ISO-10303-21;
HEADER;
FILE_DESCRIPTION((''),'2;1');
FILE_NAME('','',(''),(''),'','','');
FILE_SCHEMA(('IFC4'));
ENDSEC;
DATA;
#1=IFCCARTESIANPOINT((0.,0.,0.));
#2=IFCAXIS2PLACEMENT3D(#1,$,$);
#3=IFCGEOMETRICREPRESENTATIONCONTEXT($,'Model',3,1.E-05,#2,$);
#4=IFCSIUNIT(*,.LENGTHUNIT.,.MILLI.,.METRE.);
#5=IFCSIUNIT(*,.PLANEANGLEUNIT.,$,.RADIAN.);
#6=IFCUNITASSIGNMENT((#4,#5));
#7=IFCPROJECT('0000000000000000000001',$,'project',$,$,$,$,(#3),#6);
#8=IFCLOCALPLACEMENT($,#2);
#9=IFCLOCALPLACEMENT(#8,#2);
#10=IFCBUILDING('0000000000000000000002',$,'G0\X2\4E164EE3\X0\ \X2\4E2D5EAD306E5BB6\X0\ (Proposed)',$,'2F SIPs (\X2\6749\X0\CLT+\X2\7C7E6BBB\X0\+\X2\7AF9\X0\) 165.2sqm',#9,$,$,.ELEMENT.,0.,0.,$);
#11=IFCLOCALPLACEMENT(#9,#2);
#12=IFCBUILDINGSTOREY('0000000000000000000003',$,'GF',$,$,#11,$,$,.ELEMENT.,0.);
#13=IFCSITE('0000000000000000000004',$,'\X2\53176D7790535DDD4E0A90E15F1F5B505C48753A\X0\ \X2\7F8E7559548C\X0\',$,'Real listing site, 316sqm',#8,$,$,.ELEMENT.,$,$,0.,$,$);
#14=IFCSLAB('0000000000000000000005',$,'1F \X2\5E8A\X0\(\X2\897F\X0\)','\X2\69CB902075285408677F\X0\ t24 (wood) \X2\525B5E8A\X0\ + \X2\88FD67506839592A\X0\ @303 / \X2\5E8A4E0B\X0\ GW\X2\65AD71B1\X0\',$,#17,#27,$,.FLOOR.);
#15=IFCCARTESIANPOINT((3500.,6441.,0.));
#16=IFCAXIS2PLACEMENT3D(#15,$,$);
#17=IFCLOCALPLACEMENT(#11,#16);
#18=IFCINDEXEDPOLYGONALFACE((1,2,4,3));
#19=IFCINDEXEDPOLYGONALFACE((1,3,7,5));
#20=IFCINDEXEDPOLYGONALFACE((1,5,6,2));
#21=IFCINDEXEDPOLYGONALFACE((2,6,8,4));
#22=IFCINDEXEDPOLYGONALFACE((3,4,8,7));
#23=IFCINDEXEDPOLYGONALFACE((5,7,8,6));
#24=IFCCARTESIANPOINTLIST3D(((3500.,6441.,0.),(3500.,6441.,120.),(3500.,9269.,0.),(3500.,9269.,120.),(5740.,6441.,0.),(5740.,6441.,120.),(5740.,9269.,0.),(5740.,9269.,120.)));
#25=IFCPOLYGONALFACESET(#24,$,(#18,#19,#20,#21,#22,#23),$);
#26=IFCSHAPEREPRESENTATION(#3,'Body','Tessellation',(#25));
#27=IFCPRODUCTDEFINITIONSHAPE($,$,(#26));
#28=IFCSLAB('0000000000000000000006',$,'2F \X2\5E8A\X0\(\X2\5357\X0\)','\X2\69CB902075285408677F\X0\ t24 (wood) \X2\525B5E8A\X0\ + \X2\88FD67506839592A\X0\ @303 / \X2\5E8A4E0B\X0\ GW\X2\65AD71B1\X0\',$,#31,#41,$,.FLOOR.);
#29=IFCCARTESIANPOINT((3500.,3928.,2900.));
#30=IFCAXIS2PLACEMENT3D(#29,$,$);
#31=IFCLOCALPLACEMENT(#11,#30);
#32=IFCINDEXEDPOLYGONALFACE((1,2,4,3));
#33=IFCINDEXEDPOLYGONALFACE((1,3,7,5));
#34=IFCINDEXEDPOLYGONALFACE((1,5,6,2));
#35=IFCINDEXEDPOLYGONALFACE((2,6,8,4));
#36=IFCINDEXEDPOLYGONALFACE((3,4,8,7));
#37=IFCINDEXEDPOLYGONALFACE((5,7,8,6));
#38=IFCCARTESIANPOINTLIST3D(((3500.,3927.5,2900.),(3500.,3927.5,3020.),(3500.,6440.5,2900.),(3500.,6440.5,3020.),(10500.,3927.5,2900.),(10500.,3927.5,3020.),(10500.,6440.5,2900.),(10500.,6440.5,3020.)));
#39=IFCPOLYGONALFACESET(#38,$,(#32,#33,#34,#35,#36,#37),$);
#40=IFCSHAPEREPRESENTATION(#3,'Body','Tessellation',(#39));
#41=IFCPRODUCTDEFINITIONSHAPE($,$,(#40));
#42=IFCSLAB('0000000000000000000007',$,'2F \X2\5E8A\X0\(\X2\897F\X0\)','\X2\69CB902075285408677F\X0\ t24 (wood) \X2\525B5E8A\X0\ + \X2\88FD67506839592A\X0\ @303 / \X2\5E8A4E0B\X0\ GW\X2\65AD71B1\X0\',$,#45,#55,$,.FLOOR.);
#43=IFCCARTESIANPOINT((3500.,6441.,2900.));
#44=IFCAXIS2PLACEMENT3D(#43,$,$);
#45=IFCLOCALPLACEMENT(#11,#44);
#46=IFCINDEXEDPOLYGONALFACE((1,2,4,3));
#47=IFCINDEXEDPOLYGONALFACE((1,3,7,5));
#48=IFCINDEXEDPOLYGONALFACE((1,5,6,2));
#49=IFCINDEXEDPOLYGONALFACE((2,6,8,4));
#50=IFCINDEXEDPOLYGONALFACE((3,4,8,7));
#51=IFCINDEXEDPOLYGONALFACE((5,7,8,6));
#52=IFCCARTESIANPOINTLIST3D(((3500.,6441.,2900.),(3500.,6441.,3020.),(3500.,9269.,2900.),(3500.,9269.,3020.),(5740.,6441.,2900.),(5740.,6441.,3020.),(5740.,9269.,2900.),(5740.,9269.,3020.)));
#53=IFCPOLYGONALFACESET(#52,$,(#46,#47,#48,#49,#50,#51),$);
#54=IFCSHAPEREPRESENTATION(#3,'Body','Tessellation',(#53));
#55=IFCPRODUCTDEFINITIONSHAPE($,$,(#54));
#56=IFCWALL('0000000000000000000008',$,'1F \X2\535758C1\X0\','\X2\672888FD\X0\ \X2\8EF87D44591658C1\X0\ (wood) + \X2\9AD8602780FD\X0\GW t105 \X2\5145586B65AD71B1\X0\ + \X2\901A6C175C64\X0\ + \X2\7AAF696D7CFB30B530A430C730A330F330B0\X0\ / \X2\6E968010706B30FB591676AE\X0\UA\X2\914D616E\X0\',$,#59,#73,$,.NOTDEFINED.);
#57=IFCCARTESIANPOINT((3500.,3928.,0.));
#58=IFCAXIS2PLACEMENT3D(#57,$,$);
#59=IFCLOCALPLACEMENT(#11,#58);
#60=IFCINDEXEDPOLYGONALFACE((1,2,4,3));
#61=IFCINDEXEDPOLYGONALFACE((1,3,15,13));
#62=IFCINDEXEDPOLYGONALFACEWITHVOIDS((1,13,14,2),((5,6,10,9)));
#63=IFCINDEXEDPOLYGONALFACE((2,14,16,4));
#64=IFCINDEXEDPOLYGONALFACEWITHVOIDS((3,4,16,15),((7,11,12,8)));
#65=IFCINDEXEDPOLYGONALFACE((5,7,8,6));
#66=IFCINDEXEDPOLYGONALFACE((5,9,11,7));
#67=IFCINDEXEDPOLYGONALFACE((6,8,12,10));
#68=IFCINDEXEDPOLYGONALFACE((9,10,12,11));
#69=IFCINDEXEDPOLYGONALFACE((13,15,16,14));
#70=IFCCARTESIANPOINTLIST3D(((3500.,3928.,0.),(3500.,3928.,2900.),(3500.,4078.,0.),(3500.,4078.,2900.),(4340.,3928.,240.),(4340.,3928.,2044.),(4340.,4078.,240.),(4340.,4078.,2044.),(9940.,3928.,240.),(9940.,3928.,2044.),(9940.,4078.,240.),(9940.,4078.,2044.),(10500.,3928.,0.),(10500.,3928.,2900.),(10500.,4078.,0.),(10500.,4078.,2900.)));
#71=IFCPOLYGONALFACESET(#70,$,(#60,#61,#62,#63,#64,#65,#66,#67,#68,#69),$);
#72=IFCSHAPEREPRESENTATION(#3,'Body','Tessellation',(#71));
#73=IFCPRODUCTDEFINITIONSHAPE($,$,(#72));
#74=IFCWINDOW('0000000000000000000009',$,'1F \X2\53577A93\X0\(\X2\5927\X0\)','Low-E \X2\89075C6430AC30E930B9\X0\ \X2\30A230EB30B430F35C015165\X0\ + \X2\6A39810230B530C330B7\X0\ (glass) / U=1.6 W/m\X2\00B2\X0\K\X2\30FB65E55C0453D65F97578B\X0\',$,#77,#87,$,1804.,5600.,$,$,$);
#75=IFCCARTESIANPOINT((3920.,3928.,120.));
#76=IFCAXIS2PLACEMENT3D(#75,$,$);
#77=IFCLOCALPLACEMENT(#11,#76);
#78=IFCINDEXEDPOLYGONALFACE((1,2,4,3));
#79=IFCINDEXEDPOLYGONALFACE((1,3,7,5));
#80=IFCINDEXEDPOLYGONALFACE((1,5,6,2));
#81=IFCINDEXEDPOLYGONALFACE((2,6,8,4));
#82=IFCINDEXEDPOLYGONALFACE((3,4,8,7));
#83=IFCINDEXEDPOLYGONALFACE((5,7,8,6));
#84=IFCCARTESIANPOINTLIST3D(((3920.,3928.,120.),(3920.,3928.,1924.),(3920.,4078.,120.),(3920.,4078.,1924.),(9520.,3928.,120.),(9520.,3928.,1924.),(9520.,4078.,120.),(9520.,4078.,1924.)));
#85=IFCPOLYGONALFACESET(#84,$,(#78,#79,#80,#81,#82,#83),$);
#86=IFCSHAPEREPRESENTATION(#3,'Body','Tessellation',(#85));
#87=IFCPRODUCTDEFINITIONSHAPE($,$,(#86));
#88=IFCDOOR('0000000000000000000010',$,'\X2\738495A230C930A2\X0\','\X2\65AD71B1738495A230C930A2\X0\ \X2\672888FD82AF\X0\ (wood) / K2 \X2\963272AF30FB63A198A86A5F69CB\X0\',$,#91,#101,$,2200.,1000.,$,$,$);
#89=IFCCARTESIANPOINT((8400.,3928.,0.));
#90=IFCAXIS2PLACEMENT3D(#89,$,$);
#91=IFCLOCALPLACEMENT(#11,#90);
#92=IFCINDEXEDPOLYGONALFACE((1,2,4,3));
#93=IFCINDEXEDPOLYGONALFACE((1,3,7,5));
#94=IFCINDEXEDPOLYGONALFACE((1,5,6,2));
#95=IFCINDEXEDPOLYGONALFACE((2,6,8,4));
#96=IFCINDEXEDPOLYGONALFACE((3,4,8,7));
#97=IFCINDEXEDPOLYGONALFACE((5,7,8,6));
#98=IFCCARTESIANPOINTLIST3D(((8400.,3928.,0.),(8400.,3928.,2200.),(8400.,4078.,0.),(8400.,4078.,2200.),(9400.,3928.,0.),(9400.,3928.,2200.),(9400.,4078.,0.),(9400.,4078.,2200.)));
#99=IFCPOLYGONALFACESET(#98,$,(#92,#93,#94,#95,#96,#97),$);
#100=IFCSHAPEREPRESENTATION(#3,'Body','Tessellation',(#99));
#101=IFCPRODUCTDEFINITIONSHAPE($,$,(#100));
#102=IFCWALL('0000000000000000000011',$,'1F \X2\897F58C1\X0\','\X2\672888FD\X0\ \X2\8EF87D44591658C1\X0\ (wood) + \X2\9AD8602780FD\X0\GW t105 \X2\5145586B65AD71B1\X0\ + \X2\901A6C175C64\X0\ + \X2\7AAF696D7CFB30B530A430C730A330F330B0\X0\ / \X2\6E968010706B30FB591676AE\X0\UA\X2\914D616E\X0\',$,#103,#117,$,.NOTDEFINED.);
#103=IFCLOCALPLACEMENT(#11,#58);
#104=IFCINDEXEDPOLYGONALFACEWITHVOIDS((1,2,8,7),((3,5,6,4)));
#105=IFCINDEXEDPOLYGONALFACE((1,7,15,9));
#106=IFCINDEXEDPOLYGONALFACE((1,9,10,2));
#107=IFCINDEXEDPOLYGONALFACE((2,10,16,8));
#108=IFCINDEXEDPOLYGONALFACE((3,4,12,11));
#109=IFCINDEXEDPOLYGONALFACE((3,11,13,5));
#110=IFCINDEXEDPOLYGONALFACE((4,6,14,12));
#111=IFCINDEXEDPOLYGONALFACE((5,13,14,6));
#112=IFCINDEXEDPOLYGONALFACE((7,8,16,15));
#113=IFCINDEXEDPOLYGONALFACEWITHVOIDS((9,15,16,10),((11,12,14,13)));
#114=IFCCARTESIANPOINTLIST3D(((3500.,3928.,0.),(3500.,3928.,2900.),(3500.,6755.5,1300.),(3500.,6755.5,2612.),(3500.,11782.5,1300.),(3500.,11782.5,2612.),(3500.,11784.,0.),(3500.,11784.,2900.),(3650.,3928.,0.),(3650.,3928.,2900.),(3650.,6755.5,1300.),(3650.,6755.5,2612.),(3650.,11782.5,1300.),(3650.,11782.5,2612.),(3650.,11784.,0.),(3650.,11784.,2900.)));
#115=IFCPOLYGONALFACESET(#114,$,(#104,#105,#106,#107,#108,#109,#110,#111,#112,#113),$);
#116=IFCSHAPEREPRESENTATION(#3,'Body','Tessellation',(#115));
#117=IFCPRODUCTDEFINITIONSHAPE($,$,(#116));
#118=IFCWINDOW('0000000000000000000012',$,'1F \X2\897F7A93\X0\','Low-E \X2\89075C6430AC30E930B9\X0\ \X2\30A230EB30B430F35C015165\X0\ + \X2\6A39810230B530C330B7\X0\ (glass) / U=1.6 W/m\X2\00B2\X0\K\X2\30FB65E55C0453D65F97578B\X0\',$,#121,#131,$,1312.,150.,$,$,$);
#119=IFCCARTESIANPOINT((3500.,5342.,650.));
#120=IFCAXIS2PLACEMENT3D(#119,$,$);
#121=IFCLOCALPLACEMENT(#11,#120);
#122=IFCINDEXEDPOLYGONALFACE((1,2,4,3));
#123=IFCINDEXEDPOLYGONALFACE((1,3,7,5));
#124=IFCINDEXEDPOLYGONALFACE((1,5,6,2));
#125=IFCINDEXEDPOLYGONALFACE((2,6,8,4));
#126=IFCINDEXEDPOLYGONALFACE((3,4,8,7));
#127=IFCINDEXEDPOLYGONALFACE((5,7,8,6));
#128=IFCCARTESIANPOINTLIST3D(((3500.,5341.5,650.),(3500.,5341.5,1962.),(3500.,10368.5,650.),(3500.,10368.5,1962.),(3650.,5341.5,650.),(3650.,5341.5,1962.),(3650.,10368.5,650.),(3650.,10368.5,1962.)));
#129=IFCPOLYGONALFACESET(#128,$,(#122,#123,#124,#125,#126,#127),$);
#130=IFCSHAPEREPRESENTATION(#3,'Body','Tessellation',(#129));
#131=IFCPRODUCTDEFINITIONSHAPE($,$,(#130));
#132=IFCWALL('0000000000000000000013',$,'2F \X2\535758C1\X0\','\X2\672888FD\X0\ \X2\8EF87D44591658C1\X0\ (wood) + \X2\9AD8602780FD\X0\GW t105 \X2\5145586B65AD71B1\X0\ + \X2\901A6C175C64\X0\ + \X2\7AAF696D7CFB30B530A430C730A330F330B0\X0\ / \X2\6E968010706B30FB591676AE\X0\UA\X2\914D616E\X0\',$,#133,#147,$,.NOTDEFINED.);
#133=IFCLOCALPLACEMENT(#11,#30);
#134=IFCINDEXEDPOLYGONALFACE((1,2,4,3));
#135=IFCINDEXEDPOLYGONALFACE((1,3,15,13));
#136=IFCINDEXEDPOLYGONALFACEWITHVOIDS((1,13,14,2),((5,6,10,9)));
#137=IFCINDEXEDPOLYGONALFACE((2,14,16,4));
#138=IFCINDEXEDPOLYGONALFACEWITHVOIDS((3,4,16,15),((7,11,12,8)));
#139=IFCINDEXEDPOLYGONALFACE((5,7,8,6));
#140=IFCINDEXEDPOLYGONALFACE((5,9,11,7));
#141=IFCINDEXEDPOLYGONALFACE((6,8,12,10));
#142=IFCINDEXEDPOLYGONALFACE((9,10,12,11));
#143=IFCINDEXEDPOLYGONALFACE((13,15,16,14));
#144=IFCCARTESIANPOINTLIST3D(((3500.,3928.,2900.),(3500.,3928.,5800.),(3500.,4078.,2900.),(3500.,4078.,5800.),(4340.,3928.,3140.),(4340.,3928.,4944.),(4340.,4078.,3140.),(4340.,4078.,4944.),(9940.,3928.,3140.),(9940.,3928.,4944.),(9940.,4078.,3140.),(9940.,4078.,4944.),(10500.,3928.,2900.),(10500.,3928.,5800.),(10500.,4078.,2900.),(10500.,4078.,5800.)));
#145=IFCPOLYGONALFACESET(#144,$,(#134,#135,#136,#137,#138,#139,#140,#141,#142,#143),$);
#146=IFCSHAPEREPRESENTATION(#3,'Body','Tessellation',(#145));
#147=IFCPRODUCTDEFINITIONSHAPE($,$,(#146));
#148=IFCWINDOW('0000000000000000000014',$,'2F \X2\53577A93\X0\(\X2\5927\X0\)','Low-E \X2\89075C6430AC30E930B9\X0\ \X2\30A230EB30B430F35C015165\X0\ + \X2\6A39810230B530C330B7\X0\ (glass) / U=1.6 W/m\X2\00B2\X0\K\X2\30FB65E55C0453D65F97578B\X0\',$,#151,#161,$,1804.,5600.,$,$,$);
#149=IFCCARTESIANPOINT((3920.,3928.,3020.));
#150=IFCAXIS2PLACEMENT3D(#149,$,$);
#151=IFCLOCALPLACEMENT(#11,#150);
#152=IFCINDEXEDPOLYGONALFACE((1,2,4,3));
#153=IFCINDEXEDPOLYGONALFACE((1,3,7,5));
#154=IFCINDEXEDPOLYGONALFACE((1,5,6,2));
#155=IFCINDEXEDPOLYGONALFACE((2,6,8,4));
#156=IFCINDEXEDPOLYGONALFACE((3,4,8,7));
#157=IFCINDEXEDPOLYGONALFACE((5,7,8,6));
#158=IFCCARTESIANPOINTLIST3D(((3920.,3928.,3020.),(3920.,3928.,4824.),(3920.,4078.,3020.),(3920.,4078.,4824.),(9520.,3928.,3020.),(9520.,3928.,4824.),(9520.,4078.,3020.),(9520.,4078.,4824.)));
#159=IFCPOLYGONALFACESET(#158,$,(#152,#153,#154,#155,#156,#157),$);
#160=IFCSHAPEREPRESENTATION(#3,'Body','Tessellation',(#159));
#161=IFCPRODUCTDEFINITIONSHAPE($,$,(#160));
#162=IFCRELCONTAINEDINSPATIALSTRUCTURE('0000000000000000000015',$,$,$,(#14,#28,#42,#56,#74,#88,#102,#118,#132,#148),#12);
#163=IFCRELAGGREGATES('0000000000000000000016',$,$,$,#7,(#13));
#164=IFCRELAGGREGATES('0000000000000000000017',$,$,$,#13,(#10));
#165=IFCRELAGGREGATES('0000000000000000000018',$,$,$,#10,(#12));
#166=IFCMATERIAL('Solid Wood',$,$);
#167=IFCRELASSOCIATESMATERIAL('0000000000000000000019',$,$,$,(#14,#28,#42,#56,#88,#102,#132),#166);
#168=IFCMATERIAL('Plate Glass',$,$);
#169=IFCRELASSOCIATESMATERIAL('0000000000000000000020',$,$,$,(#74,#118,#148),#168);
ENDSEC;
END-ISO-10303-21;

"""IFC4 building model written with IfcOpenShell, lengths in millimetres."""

from ifc_helpers import new_model, si_unit, frame, frame_2d, origin, place, context, project, spatial, rectangle, extrude, material, element, fill, save


model = new_model("IFC4")

# Units and contexts
model_context = context("Model", 3, precision=1e-05, world=origin())
ifc_project = project(units=[si_unit("LENGTHUNIT", "METRE", prefix="MILLI"), si_unit("PLANEANGLEUNIT", "RADIAN")], contexts=[model_context])

# Site, building, storey
site_placement = place(None, origin())
site = spatial("IfcSite", under=ifc_project, at=site_placement, Name="北海道川上郡弟子屈町 美留和", ObjectType="Real listing site, 316sqm", CompositionType="ELEMENT", RefElevation=0.0)
building_placement = place(site_placement, origin())
building = spatial("IfcBuilding", under=site, at=building_placement, Name="G0世代 中庭の家 (Proposed)", ObjectType="2F SIPs (杉CLT+籾殻+竹) 165.2sqm", CompositionType="ELEMENT", ElevationOfRefHeight=0.0, ElevationOfTerrain=0.0)
storey_placement = place(building_placement, origin())
storey = spatial("IfcBuildingStorey", under=building, at=storey_placement, Name="GF", CompositionType="ELEMENT", Elevation=0.0)

# Slabs
ifc_material_1 = material(Name="Solid Wood")
slab_1_placement = place(storey_placement, frame((3500.0, 6441.0, 0.0)))
element("IfcSlab", 1, at=slab_1_placement, inside=storey, material=ifc_material_1, Name="1F 床(西)", Description="構造用合板 t24 (wood) 剛床 + 製材根太 @303 / 床下 GW断熱", PredefinedType="FLOOR", context=model_context, shape_type="SweptSolid", body=[
    extrude(rectangle(XDim=2240.0, YDim=2828.0, at=frame_2d((1120.0, 1414.0))), frame((3500.0, 6441.0, 0.0)), (0.0, 0.0, 1.0), 120.0),
])
slab_2_placement = place(storey_placement, frame((3500.0, 3928.0, 2900.0)))
element("IfcSlab", 2, at=slab_2_placement, inside=storey, material=ifc_material_1, Name="2F 床(南)", Description="構造用合板 t24 (wood) 剛床 + 製材根太 @303 / 床下 GW断熱", PredefinedType="FLOOR", context=model_context, shape_type="SweptSolid", body=[
    extrude(rectangle(XDim=7000.0, YDim=2513.0, at=frame_2d((3500.0, 1256.0))), frame((3500.0, 3928.0, 2900.0)), (0.0, 0.0, 1.0), 120.0),
])
slab_3_placement = place(storey_placement, frame((3500.0, 6441.0, 2900.0)))
element("IfcSlab", 3, at=slab_3_placement, inside=storey, material=ifc_material_1, Name="2F 床(西)", Description="構造用合板 t24 (wood) 剛床 + 製材根太 @303 / 床下 GW断熱", PredefinedType="FLOOR", context=model_context, shape_type="SweptSolid", body=[
    extrude(rectangle(XDim=2240.0, YDim=2828.0, at=frame_2d((1120.0, 1414.0))), frame((3500.0, 6441.0, 2900.0)), (0.0, 0.0, 1.0), 120.0),
])

# Wall, openings, window, door
wall_1_placement = place(storey_placement, frame((3500.0, 3928.0, 0.0)))
wall_1 = element("IfcWall", 4, at=wall_1_placement, inside=storey, material=ifc_material_1, Name="1F 南壁", Description="木製 軸組外壁 (wood) + 高性能GW t105 充填断熱 + 通気層 + 窯業系サイディング / 準耐火・外皮UA配慮", PredefinedType="NOTDEFINED", context=model_context, shape_type="SweptSolid", body=[
    extrude(rectangle(XDim=7000.0, YDim=150.0, at=frame_2d((3500.0, 75.0))), frame((3500.0, 3928.0, 0.0)), (0.0, 0.0, 1.0), 2900.0),
])
opening_1_placement = place(storey_placement, frame((3920.0, 3928.0, 120.0)))
opening_1 = element("IfcOpeningElement", 5, at=opening_1_placement, cuts=wall_1, PredefinedType="NOTDEFINED", context=model_context, shape_type="SweptSolid", body=[
    extrude(rectangle(XDim=5600.0, YDim=150.0, at=frame_2d((2800.0, 75.0))), frame((3920.0, 3928.0, 120.0)), (0.0, 0.0, 1.0), 1804.0),
])
opening_2_placement = place(storey_placement, frame((8400.0, 3928.0, 0.0)))
opening_2 = element("IfcOpeningElement", 6, at=opening_2_placement, cuts=wall_1, PredefinedType="NOTDEFINED", context=model_context, shape_type="SweptSolid", body=[
    extrude(rectangle(XDim=1000.0, YDim=150.0, at=frame_2d((500.0, 75.0))), frame((8400.0, 3928.0, 0.0)), (0.0, 0.0, 1.0), 2200.0),
])
ifc_material_2 = material(Name="Plate Glass")
window_1_placement = place(storey_placement, frame((3920.0, 3928.0, 120.0)))
window_1 = element("IfcWindow", 7, at=window_1_placement, inside=storey, material=ifc_material_2, Name="1F 南窓(大)", Description="Low-E 複層ガラス アルゴン封入 + 樹脂サッシ (glass) / U=1.6 W/m²K・日射取得型", OverallHeight=1804.0, OverallWidth=5600.0, context=model_context, shape_type="SweptSolid", body=[
    extrude(rectangle(XDim=5600.0, YDim=150.0, at=frame_2d((2800.0, 75.0))), frame((3920.0, 3928.0, 120.0)), (0.0, 0.0, 1.0), 1804.0),
])
fill(opening_1, window_1)
door_placement = place(storey_placement, frame((8400.0, 3928.0, 0.0)))
door = element("IfcDoor", 8, at=door_placement, inside=storey, material=ifc_material_1, Name="玄関ドア", Description="断熱玄関ドア 木製芯 (wood) / K2 防犯・採風機構", OverallHeight=2200.0, OverallWidth=1000.0, context=model_context, shape_type="SweptSolid", body=[
    extrude(rectangle(XDim=1000.0, YDim=150.0, at=frame_2d((500.0, 75.0))), frame((8400.0, 3928.0, 0.0)), (0.0, 0.0, 1.0), 2200.0),
])
fill(opening_2, door)

# Walls, openings, windows
wall_2_placement = place(storey_placement, frame((3500.0, 3928.0, 0.0)))
wall_2 = element("IfcWall", 9, at=wall_2_placement, inside=storey, material=ifc_material_1, Name="1F 西壁", Description="木製 軸組外壁 (wood) + 高性能GW t105 充填断熱 + 通気層 + 窯業系サイディング / 準耐火・外皮UA配慮", PredefinedType="NOTDEFINED", context=model_context, shape_type="SweptSolid", body=[
    extrude(rectangle(XDim=150.0, YDim=7856.0, at=frame_2d((75.0, 3928.0))), frame((3500.0, 3928.0, 0.0)), (0.0, 0.0, 1.0), 2900.0),
])
opening_3_placement = place(storey_placement, frame((3500.0, 5342.0, 650.0)))
opening_3 = element("IfcOpeningElement", 10, at=opening_3_placement, cuts=wall_2, PredefinedType="NOTDEFINED", context=model_context, shape_type="SweptSolid", body=[
    extrude(rectangle(XDim=150.0, YDim=5027.0, at=frame_2d((75.0, 2513.0))), frame((3500.0, 5342.0, 650.0)), (0.0, 0.0, 1.0), 1312.0),
])
window_2_placement = place(storey_placement, frame((3500.0, 5342.0, 650.0)))
window_2 = element("IfcWindow", 11, at=window_2_placement, inside=storey, material=ifc_material_2, Name="1F 西窓", Description="Low-E 複層ガラス アルゴン封入 + 樹脂サッシ (glass) / U=1.6 W/m²K・日射取得型", OverallHeight=1312.0, OverallWidth=150.0, context=model_context, shape_type="SweptSolid", body=[
    extrude(rectangle(XDim=150.0, YDim=5027.0, at=frame_2d((75.0, 2513.0))), frame((3500.0, 5342.0, 650.0)), (0.0, 0.0, 1.0), 1312.0),
])
fill(opening_3, window_2)
wall_3_placement = place(storey_placement, frame((3500.0, 3928.0, 2900.0)))
wall_3 = element("IfcWall", 12, at=wall_3_placement, inside=storey, material=ifc_material_1, Name="2F 南壁", Description="木製 軸組外壁 (wood) + 高性能GW t105 充填断熱 + 通気層 + 窯業系サイディング / 準耐火・外皮UA配慮", PredefinedType="NOTDEFINED", context=model_context, shape_type="SweptSolid", body=[
    extrude(rectangle(XDim=7000.0, YDim=150.0, at=frame_2d((3500.0, 75.0))), frame((3500.0, 3928.0, 2900.0)), (0.0, 0.0, 1.0), 2900.0),
])
opening_4_placement = place(storey_placement, frame((3920.0, 3928.0, 3020.0)))
opening_4 = element("IfcOpeningElement", 13, at=opening_4_placement, cuts=wall_3, PredefinedType="NOTDEFINED", context=model_context, shape_type="SweptSolid", body=[
    extrude(rectangle(XDim=5600.0, YDim=150.0, at=frame_2d((2800.0, 75.0))), frame((3920.0, 3928.0, 3020.0)), (0.0, 0.0, 1.0), 1804.0),
])
window_3_placement = place(storey_placement, frame((3920.0, 3928.0, 3020.0)))
window_3 = element("IfcWindow", 14, at=window_3_placement, inside=storey, material=ifc_material_2, Name="2F 南窓(大)", Description="Low-E 複層ガラス アルゴン封入 + 樹脂サッシ (glass) / U=1.6 W/m²K・日射取得型", OverallHeight=1804.0, OverallWidth=5600.0, context=model_context, shape_type="SweptSolid", body=[
    extrude(rectangle(XDim=5600.0, YDim=150.0, at=frame_2d((2800.0, 75.0))), frame((3920.0, 3928.0, 3020.0)), (0.0, 0.0, 1.0), 1804.0),
])
fill(opening_4, window_3)

save(model, "model.ifc")
